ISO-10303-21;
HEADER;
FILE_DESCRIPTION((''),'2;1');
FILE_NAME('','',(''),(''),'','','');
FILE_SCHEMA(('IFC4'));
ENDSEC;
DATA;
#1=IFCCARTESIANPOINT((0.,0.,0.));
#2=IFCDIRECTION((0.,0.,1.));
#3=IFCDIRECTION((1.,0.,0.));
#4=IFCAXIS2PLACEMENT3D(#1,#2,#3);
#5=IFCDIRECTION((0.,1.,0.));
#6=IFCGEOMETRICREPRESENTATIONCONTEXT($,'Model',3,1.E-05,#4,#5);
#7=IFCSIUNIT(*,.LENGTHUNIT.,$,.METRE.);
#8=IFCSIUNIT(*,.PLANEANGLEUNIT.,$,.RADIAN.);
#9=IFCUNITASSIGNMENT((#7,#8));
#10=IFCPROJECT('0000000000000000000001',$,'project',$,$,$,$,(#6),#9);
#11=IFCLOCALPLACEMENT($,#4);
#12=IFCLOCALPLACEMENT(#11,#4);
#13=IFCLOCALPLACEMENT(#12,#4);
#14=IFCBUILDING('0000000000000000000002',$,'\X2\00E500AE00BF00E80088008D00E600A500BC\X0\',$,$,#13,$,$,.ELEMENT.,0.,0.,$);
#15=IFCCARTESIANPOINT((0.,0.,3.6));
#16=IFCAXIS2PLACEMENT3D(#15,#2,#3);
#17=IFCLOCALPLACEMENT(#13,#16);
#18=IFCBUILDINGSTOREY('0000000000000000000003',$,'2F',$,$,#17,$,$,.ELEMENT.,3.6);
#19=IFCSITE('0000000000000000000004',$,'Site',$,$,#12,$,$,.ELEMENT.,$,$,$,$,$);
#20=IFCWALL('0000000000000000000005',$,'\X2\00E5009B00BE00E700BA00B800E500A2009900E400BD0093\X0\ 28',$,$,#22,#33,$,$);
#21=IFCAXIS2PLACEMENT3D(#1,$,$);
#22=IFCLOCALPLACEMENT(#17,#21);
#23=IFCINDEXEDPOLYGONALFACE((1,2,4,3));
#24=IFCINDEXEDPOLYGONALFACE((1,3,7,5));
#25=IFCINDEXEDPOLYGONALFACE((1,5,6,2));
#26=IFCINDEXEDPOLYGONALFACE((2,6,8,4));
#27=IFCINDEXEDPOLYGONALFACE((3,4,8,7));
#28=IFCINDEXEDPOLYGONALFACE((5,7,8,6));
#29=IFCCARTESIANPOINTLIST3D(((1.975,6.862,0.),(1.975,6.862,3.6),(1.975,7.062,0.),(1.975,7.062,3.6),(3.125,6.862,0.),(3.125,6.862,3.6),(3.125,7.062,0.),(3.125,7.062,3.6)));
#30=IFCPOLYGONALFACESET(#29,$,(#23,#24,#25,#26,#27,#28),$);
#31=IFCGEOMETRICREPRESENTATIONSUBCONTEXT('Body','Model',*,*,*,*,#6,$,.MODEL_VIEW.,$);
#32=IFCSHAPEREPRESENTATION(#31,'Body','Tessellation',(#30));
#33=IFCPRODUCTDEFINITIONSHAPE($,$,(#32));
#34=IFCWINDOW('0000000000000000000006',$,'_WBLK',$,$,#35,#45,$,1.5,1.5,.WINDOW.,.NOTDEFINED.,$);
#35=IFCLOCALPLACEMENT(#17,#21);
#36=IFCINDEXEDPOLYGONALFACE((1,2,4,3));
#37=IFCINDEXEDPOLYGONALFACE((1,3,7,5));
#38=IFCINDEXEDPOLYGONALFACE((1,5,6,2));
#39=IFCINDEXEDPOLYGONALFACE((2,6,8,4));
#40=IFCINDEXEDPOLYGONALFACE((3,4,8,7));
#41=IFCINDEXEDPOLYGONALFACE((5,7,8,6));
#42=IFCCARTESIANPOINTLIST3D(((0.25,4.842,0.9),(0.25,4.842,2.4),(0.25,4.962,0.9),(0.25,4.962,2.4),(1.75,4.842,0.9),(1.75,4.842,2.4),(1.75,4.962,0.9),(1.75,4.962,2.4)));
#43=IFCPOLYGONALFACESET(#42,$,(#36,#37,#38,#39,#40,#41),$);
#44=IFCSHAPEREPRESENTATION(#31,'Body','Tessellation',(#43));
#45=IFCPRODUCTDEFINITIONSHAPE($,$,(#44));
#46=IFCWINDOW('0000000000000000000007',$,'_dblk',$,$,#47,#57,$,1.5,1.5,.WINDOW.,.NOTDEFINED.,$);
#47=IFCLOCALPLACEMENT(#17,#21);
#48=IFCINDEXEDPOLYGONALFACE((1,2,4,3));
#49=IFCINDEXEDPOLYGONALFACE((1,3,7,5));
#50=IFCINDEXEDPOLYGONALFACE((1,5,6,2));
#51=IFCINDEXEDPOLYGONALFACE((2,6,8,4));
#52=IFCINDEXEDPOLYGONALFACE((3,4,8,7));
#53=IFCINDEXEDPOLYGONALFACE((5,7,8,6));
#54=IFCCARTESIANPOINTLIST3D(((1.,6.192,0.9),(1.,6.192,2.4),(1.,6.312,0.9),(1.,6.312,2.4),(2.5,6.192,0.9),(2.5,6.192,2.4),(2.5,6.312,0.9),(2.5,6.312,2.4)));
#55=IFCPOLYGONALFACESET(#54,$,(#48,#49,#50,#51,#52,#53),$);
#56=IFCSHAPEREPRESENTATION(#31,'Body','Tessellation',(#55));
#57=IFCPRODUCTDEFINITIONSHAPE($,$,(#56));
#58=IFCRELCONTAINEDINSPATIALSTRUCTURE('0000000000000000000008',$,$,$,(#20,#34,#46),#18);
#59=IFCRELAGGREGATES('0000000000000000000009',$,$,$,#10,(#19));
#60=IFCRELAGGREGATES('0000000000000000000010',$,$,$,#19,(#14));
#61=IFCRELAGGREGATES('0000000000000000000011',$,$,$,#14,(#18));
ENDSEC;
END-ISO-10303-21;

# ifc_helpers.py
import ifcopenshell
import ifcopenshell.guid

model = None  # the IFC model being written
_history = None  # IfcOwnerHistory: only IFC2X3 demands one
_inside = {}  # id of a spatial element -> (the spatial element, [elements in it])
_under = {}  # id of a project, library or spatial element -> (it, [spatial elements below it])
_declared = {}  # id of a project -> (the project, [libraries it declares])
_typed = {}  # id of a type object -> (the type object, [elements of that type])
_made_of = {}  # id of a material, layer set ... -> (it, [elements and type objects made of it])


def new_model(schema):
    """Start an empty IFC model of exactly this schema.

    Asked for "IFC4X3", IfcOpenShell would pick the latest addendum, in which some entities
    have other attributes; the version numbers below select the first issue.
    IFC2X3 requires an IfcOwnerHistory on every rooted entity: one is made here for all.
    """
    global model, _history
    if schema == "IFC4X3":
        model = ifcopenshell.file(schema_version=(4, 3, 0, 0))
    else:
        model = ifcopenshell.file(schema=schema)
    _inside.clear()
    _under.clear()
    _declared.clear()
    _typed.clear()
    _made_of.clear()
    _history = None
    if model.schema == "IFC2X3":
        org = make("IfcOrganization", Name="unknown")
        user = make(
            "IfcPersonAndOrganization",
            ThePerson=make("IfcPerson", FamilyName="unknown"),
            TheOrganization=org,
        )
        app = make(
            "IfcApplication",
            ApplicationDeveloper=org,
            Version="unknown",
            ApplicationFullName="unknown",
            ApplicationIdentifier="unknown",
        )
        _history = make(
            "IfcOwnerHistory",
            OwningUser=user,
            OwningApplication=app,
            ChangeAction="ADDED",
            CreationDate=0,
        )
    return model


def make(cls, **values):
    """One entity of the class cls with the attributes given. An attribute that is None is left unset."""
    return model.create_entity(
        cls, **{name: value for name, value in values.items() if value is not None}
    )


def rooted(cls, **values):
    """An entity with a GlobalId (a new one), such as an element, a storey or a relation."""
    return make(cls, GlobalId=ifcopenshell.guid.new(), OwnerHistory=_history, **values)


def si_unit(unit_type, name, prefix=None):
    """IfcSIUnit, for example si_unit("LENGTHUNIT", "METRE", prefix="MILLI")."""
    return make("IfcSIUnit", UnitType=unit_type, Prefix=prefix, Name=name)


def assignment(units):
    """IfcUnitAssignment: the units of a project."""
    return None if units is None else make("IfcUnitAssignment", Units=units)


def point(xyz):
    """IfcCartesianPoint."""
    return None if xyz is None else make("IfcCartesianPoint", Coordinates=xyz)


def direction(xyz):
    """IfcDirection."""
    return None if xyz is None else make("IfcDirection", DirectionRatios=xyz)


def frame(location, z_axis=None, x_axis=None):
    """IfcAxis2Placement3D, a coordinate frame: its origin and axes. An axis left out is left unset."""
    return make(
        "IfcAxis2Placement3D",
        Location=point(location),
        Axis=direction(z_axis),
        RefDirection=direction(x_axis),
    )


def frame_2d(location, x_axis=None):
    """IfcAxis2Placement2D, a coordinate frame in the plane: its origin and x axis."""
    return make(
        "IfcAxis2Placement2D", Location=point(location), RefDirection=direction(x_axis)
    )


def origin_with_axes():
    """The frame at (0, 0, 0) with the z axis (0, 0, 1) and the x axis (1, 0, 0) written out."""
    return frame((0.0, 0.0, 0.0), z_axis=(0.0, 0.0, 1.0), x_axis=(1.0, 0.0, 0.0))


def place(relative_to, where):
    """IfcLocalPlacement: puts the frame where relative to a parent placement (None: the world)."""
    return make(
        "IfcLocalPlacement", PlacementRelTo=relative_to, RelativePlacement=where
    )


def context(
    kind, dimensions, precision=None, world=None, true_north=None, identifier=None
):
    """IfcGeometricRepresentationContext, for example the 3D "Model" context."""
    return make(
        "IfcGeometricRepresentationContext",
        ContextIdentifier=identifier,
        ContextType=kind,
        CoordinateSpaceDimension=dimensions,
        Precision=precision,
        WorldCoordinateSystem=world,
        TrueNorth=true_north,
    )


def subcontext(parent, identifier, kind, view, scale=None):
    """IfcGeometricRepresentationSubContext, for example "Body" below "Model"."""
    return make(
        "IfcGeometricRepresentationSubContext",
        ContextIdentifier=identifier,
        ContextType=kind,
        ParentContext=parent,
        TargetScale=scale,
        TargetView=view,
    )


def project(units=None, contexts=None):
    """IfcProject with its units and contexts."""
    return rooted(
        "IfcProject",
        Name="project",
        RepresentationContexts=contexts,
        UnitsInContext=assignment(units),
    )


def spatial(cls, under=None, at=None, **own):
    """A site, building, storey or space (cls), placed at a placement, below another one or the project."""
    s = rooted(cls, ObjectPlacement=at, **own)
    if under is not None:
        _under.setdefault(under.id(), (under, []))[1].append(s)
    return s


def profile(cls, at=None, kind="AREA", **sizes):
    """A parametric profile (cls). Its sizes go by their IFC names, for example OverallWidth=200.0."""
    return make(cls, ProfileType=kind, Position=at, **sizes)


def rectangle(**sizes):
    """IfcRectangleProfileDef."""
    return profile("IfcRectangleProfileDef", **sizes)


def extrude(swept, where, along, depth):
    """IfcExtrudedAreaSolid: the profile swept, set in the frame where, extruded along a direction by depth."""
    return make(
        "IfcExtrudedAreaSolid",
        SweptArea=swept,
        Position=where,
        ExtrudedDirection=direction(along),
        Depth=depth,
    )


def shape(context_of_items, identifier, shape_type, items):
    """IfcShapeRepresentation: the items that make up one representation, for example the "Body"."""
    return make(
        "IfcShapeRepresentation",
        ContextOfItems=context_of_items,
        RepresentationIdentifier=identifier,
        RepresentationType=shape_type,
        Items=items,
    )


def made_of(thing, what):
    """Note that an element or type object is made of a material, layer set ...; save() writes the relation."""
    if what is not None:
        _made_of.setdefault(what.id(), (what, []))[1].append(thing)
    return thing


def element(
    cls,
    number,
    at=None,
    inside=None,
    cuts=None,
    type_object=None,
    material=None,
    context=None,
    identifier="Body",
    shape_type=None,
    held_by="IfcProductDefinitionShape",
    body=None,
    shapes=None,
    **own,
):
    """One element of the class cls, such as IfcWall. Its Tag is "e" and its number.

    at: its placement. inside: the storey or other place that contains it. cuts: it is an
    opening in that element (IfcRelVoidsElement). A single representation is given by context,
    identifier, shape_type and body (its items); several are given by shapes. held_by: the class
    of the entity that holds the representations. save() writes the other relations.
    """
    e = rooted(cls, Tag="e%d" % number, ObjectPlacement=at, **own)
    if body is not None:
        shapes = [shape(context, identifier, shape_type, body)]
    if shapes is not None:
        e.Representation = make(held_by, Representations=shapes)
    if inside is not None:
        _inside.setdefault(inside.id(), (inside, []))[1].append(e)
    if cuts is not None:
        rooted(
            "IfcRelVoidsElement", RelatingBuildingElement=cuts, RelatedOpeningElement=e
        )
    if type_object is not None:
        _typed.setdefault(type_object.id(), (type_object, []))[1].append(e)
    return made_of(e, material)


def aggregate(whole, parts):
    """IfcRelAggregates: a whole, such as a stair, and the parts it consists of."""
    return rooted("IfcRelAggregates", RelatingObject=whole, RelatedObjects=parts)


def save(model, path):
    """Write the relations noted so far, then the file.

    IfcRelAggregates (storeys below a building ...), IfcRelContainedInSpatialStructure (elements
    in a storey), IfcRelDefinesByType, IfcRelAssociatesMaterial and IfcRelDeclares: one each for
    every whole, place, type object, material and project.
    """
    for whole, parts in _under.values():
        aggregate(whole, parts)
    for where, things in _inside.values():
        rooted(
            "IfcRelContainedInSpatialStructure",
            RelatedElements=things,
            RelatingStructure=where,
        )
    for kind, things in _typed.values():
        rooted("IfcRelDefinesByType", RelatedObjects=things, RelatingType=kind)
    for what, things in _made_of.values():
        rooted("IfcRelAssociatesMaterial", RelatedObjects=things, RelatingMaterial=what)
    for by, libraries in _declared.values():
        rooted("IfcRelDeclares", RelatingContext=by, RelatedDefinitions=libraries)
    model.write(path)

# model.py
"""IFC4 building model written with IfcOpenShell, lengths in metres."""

from ifc_helpers import new_model, si_unit, direction, frame, frame_2d, origin_with_axes, place, context, subcontext, project, spatial, rectangle, extrude, element, save


model = new_model("IFC4")

# Units and contexts
model_context = context("Model", 3, precision=1e-05, world=origin_with_axes(), true_north=direction((0.0, 1.0, 0.0)))
body_context = subcontext(model_context, "Body", "Model", "MODEL_VIEW")
ifc_project = project(units=[si_unit("LENGTHUNIT", "METRE"), si_unit("PLANEANGLEUNIT", "RADIAN")], contexts=[model_context])

# Site, building, storey
placement = place(None, origin_with_axes())
site_placement = place(placement, origin_with_axes())
site = spatial("IfcSite", under=ifc_project, at=site_placement, Name="Site", CompositionType="ELEMENT")
building_placement = place(site_placement, origin_with_axes())
building = spatial("IfcBuilding", under=site, at=building_placement, Name="å®¿è\u0088\u008dæ¥¼", CompositionType="ELEMENT", ElevationOfRefHeight=0.0, ElevationOfTerrain=0.0)
storey_placement = place(building_placement, frame((0.0, 0.0, 3.6), z_axis=(0.0, 0.0, 1.0), x_axis=(1.0, 0.0, 0.0)))
storey = spatial("IfcBuildingStorey", under=building, at=storey_placement, Name="2F", CompositionType="ELEMENT", Elevation=3.6)

# Wall
wall_1_placement = place(storey_placement, frame((2.55, 6.962, 0.0), z_axis=(0.0, 0.0, 1.0), x_axis=(-1.0, 0.0, 0.0)))
element("IfcWall", 1, at=wall_1_placement, inside=storey, Name="å\u009b¾çº¸å¢\u0099ä½\u0093 28", context=body_context, shape_type="SweptSolid", body=[
    extrude(rectangle(XDim=1.15, YDim=0.2, at=frame_2d((0.0, 0.0), x_axis=(1.0, 0.0, 0.0))), frame((0.0, 0.0, 0.0), z_axis=(0.0, 0.0, 1.0)), (0.0, 0.0, 1.0), 3.6),
])

# Windows
for number, where, z_axis, x_axis, name in (
    (2, (1.0, 4.902, 0.9), (0.0, 0.0, 1.0), (1.0, 0.0, 0.0), "_WBLK"),
    (3, (1.75, 6.252, 0.9), (0.0, 0.0, 1.0), (1.0, 0.0, 0.0), "_dblk"),
):
    element("IfcWindow", number, at=place(storey_placement, frame(where, z_axis=z_axis, x_axis=x_axis)), inside=storey, Name=name, OverallHeight=1.5, OverallWidth=1.5, PartitioningType="NOTDEFINED", PredefinedType="WINDOW", context=body_context, shape_type="SweptSolid", body=[
        extrude(rectangle(XDim=1.5, YDim=0.12, at=frame_2d((0.0, 0.0), x_axis=(1.0, 0.0, 0.0))), frame((0.0, 0.0, 0.0), z_axis=(0.0, 0.0, 1.0)), (0.0, 0.0, 1.0), 1.5),
    ])

save(model, "model.ifc")
